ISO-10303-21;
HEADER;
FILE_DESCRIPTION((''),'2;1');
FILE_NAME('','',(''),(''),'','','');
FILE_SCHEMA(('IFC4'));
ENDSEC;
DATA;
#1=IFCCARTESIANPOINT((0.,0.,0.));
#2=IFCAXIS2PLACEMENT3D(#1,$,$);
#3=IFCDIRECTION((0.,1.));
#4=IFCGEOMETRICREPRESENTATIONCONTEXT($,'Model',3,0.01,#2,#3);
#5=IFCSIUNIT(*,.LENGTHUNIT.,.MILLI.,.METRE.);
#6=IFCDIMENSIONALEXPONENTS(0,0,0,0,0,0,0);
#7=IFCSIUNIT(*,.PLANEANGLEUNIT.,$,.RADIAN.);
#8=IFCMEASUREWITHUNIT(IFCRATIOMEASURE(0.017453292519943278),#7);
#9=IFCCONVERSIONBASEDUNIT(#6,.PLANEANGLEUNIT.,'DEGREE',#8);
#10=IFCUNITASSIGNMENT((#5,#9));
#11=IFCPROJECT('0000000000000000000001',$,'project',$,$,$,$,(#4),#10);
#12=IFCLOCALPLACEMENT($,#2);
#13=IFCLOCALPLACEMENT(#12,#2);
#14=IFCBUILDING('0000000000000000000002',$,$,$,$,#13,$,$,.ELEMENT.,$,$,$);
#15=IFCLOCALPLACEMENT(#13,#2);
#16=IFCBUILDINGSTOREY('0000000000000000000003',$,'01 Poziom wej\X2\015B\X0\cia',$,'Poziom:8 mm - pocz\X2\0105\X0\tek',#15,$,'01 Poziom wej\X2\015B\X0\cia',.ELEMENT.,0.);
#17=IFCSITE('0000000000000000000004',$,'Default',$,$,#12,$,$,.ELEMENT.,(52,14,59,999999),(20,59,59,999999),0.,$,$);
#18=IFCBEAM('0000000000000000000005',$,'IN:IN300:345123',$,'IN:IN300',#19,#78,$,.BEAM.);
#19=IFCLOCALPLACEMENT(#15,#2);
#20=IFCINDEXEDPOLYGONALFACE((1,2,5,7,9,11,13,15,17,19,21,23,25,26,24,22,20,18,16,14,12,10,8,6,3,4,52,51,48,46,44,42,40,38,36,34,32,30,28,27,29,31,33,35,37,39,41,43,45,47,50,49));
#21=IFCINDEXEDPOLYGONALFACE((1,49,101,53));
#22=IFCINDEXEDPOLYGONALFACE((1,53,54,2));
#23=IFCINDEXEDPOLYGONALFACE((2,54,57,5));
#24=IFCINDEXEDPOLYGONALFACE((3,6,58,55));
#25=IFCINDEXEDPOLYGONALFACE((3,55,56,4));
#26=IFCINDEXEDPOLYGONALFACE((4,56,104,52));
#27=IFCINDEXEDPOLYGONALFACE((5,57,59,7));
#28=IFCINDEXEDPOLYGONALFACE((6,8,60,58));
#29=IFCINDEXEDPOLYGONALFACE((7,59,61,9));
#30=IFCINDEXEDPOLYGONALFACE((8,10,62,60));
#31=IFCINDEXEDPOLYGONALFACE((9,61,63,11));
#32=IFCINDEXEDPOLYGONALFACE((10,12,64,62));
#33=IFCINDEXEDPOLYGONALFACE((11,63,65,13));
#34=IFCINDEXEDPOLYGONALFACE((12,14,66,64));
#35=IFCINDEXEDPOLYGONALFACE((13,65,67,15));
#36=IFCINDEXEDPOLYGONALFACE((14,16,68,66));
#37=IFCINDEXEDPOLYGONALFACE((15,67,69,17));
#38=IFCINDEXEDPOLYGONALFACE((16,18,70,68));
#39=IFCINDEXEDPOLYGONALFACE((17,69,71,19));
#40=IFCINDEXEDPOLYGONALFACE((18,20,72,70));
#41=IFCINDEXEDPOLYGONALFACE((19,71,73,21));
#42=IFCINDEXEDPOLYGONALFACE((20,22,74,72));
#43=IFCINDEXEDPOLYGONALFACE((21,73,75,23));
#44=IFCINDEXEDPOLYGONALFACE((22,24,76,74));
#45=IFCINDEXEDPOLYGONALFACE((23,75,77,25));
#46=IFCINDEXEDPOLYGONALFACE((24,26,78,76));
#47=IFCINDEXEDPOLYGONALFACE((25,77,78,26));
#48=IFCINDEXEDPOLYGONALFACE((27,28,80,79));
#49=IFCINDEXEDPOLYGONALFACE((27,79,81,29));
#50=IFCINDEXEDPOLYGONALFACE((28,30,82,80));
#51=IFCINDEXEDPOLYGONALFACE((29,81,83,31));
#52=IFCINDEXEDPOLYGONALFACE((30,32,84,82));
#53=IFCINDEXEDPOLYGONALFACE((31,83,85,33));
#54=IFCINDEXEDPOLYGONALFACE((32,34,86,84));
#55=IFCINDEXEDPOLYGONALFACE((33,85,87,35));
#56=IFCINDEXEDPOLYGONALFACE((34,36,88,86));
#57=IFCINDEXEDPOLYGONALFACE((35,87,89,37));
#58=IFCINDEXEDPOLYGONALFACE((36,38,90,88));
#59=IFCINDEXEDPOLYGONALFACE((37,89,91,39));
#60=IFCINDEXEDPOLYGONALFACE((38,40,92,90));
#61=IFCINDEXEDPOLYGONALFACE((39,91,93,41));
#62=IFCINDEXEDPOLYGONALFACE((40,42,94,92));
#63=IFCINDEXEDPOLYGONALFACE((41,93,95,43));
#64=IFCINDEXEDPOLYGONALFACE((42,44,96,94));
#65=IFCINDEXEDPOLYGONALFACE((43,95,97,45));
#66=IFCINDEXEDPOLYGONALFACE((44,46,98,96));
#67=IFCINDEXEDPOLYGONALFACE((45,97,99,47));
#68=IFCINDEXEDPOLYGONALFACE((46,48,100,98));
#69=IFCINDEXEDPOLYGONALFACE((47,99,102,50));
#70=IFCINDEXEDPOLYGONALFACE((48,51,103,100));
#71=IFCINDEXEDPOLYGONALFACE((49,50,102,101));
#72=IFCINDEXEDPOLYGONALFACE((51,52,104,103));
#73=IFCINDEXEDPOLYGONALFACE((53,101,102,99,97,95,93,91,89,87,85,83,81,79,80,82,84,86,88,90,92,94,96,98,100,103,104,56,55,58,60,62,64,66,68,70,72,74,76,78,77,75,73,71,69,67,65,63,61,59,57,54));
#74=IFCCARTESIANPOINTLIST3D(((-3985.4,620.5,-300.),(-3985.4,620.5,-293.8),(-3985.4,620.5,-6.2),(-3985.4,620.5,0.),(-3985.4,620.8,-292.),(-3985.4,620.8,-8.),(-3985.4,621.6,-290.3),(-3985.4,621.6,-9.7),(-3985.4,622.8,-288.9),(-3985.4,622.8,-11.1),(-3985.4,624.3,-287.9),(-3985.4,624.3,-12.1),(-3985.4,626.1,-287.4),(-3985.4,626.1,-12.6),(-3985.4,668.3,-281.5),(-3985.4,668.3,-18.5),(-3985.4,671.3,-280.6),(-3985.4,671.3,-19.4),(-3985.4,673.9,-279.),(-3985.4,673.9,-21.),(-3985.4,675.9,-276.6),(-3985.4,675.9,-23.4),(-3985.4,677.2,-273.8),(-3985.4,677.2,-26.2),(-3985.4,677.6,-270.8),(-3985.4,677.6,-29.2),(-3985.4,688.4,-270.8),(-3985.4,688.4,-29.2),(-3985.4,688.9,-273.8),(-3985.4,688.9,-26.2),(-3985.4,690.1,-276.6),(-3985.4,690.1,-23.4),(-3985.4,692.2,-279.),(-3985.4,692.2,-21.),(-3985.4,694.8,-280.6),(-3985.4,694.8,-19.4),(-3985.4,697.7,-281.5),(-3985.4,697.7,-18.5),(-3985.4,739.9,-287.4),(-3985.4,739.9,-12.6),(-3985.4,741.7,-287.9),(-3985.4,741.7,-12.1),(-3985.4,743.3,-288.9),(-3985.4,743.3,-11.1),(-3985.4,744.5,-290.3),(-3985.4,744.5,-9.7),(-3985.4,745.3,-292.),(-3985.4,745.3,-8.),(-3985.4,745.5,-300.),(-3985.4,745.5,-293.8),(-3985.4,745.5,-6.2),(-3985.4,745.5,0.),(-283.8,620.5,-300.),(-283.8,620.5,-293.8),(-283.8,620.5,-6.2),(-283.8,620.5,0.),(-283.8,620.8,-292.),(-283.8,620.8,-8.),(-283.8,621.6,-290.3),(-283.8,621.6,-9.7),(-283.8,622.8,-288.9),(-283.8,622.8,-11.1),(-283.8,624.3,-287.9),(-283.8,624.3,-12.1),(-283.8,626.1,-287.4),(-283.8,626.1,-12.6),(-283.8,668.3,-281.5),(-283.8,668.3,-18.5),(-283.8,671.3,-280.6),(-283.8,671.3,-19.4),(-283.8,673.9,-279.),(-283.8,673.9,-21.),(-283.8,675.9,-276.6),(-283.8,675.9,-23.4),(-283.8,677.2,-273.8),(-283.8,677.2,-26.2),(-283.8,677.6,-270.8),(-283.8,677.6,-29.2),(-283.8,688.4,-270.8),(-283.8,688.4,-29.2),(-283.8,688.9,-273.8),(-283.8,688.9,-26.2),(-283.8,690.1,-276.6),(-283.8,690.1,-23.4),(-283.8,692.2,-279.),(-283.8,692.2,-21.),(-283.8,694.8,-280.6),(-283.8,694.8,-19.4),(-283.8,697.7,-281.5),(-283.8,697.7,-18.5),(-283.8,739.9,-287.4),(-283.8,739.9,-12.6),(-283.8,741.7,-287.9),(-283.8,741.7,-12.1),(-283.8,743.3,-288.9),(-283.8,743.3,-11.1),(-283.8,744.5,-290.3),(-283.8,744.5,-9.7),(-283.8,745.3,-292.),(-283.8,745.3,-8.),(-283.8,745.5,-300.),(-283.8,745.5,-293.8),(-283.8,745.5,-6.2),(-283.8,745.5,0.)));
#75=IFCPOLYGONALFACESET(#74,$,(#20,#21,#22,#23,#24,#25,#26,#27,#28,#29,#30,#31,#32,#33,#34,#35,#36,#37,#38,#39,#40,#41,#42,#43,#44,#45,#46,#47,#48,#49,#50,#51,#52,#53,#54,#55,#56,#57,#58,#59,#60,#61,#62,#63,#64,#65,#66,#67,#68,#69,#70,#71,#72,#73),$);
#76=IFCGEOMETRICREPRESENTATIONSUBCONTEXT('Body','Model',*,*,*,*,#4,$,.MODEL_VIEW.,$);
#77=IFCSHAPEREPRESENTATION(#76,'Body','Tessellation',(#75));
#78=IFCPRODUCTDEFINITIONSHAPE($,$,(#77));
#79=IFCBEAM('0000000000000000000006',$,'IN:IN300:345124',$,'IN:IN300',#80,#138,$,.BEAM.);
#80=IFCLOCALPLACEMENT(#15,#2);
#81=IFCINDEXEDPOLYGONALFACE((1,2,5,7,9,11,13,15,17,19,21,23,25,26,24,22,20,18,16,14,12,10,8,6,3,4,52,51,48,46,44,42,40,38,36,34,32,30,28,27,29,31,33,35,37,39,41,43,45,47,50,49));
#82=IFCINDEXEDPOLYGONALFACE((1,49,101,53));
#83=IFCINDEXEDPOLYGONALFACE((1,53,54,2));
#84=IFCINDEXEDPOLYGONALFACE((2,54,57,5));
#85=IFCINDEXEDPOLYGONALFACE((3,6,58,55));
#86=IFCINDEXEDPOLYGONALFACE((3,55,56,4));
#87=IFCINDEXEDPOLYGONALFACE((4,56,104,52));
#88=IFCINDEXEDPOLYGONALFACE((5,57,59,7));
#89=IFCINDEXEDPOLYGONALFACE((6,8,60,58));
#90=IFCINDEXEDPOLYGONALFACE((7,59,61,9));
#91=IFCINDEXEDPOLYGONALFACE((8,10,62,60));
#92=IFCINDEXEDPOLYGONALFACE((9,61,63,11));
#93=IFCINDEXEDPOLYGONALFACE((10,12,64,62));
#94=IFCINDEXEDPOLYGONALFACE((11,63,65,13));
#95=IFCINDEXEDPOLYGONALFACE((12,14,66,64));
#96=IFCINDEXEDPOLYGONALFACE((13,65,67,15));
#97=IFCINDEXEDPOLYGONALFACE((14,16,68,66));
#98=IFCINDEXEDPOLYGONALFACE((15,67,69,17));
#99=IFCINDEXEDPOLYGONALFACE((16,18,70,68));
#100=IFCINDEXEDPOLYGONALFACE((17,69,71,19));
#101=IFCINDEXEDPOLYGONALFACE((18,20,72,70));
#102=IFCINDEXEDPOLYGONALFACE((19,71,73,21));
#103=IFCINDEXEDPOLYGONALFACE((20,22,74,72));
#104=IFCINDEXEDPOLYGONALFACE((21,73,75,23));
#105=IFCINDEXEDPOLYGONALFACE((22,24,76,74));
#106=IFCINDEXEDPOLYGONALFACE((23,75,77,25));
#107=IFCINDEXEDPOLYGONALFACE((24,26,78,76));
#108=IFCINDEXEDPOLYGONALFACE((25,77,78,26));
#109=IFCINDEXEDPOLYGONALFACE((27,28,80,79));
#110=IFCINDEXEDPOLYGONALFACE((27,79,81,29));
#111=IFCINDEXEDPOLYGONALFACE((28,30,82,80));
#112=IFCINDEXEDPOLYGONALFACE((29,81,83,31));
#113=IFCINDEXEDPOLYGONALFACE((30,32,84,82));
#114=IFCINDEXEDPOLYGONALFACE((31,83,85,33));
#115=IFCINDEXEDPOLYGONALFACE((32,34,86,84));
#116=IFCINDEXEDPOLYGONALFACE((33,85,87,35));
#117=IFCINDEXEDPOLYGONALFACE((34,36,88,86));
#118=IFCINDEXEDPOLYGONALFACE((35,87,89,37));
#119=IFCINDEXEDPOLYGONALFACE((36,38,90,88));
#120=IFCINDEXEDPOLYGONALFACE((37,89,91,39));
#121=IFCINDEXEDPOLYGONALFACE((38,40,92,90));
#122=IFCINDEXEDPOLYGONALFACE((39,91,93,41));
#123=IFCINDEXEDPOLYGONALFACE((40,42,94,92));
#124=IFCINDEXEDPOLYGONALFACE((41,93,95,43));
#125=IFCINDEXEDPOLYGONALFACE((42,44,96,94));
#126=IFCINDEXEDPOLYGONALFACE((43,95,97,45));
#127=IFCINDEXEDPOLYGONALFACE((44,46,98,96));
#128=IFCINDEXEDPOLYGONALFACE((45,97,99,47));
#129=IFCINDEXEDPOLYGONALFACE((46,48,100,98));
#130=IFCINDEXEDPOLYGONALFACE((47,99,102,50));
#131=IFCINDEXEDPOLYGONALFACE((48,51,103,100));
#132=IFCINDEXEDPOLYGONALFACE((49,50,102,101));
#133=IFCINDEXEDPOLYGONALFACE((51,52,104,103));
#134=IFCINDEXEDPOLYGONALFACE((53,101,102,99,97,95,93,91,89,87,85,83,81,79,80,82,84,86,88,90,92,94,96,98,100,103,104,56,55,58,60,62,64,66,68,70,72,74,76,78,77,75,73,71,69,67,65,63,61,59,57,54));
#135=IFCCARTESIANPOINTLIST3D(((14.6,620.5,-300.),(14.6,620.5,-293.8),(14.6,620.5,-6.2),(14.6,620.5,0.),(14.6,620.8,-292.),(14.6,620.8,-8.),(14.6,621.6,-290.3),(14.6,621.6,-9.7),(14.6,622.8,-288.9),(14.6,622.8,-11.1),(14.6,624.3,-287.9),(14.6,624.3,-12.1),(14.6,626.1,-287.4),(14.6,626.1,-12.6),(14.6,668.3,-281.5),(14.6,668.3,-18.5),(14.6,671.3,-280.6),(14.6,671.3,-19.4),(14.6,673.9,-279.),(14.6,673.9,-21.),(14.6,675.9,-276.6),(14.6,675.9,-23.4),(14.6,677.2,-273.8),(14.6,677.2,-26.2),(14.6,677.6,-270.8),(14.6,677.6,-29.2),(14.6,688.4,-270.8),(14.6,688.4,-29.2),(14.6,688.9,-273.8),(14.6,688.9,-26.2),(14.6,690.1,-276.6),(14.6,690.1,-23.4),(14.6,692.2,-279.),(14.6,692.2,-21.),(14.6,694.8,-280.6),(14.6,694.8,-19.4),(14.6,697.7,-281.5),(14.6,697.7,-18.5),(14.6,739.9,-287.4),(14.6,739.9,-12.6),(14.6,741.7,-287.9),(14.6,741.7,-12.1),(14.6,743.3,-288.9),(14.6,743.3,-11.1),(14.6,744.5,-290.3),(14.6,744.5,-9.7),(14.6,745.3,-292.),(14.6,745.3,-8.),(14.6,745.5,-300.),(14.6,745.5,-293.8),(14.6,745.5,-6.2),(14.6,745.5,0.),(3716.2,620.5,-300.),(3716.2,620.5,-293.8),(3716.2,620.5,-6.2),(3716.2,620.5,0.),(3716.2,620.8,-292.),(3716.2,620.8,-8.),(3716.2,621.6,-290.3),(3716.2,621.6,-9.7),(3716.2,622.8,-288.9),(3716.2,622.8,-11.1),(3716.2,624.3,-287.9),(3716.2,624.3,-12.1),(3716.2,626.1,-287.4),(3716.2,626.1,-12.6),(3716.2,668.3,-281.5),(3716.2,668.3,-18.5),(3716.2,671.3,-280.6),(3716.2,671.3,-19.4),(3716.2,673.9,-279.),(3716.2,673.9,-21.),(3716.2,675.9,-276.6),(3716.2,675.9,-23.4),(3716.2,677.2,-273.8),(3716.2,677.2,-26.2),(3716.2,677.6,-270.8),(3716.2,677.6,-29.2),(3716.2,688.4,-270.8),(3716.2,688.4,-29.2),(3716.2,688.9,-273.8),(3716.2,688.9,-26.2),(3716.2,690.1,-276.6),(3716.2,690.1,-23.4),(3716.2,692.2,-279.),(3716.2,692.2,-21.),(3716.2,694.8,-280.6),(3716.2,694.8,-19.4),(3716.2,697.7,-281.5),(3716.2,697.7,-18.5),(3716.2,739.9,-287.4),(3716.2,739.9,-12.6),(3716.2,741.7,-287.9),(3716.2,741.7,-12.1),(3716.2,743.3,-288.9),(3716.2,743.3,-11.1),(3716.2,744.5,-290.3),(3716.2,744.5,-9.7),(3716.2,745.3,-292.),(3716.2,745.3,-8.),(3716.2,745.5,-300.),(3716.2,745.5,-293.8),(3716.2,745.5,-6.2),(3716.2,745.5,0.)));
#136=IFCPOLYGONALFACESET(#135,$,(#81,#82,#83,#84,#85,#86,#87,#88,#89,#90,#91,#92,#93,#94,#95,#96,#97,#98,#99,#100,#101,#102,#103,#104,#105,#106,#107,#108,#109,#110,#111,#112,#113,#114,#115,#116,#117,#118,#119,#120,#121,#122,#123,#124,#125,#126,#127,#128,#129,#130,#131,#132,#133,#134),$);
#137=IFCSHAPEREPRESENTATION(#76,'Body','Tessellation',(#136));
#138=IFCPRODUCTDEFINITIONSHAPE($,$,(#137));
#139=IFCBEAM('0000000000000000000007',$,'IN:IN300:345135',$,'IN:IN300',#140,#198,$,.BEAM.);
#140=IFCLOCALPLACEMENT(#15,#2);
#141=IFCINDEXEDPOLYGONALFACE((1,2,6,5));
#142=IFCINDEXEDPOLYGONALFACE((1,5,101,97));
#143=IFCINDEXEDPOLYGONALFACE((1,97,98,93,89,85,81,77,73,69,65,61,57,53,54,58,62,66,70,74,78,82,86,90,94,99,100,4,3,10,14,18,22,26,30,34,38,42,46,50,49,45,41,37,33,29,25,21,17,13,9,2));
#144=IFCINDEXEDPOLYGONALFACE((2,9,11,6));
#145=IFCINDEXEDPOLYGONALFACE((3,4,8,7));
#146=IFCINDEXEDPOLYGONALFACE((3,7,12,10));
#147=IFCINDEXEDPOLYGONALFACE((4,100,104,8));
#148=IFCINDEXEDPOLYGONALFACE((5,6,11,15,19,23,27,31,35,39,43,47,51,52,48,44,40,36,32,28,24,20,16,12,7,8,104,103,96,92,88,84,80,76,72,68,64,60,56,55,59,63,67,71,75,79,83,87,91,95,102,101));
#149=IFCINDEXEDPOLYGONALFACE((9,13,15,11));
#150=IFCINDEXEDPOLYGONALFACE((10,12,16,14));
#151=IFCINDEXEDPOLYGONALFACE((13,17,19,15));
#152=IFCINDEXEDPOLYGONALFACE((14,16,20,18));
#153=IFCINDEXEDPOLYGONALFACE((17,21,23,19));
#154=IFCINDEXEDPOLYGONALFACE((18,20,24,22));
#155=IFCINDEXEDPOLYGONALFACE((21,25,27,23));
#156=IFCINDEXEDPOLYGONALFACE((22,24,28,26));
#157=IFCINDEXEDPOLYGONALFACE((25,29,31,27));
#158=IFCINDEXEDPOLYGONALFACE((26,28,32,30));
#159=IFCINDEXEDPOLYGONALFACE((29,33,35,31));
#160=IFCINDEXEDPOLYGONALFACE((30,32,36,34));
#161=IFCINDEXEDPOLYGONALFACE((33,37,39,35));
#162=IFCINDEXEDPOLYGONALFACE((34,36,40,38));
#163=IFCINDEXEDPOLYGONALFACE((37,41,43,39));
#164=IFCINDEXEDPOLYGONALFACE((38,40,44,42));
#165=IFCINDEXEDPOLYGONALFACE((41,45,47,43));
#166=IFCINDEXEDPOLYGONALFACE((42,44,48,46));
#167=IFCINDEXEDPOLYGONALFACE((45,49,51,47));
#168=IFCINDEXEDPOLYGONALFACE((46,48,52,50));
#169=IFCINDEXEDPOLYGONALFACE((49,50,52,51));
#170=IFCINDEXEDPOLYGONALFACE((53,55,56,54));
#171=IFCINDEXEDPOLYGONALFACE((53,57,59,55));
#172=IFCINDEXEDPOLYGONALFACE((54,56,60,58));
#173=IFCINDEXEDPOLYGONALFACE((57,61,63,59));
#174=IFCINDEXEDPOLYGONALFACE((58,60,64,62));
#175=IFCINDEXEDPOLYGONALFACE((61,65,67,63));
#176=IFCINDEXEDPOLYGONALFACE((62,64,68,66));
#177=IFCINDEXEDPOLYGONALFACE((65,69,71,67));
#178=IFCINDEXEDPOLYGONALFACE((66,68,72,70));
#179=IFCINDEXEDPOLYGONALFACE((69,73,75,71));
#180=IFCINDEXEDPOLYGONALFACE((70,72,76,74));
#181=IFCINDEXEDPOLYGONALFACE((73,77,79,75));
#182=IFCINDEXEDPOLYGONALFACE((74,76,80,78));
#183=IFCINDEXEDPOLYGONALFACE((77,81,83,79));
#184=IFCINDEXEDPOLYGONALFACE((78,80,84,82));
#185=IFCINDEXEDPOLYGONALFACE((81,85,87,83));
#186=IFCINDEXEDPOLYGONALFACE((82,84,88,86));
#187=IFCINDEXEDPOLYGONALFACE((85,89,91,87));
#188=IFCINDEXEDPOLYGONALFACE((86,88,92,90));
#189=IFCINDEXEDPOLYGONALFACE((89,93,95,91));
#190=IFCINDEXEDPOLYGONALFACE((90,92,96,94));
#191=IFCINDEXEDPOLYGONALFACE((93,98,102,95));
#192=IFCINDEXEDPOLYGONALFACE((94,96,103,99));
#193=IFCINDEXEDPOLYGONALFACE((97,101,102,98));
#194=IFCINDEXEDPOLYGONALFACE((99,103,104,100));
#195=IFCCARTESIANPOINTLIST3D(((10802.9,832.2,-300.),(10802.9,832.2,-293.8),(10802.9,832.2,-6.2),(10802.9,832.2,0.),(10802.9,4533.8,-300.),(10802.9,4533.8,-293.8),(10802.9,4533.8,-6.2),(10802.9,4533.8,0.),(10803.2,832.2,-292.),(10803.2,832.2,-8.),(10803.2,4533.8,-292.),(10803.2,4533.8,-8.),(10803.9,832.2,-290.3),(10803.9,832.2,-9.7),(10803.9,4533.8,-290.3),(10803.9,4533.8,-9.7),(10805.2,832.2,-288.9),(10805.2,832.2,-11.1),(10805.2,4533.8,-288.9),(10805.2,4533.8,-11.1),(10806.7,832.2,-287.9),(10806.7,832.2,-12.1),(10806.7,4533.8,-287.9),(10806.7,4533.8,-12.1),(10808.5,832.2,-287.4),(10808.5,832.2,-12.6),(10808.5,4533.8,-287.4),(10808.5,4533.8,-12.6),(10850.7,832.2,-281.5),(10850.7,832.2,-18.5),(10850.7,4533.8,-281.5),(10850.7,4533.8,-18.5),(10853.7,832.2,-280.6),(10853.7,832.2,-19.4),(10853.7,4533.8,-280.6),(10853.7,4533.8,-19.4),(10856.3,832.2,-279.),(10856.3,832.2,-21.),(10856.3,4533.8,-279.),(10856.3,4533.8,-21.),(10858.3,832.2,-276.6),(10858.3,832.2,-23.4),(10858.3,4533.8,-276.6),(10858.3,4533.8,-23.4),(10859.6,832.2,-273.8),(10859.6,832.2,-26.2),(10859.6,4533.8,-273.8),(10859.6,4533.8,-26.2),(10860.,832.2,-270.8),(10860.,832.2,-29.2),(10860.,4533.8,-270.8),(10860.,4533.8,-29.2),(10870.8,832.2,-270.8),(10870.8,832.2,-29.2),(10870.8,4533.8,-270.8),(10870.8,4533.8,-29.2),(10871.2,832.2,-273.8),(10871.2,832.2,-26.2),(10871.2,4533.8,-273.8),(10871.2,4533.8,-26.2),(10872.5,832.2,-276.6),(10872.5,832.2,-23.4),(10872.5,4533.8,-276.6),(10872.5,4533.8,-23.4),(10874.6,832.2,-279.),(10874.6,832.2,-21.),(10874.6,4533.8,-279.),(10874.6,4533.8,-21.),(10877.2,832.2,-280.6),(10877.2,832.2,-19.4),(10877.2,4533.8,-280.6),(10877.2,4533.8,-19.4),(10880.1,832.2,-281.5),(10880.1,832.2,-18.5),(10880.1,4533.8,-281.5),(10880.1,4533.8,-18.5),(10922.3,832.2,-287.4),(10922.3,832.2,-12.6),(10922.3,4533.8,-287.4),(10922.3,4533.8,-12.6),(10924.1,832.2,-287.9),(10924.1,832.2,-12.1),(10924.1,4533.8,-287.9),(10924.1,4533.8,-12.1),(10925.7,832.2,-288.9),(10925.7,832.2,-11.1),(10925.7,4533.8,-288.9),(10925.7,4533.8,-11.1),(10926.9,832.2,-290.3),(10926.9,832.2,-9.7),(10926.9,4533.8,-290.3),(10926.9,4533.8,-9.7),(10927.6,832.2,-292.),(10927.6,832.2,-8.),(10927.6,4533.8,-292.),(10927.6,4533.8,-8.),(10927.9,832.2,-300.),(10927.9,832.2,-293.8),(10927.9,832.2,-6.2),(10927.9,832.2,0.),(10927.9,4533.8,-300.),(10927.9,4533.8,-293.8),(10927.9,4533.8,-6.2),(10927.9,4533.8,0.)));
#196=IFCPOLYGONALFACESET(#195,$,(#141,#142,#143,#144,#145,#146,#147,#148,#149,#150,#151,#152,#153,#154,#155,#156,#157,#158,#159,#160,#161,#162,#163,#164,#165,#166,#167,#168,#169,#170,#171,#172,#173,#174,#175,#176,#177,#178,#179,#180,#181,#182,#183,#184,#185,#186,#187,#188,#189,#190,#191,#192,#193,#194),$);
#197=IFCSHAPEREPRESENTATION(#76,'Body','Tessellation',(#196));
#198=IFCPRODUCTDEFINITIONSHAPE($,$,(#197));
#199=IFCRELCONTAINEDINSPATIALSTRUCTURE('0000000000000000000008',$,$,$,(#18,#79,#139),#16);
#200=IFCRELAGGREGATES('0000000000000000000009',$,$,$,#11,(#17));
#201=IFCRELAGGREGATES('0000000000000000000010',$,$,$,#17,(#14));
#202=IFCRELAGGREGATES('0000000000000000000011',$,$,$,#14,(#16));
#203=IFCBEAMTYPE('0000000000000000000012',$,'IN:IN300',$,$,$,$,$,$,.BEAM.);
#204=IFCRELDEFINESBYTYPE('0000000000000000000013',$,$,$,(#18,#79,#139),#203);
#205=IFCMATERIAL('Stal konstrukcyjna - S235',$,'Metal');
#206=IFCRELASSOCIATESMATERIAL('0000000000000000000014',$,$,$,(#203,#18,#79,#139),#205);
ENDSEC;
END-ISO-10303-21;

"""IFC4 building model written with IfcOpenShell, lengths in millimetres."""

from ifc_helpers import new_model, entity, si_unit, converted_unit, direction, frame, origin, place, context, subcontext, project, spatial, line, arc, indexed_curve, outline, extrude, source, transform, mapped, material, type_object, type_shapes, element, save


model = new_model("IFC4")

# Units and contexts
model_context = context("Model", 3, precision=0.01, world=origin(), true_north=direction((0.0, 1.0)))
body_context = subcontext(model_context, "Body", "Model", "MODEL_VIEW")
ifc_project = project(units=[si_unit("LENGTHUNIT", "METRE", prefix="MILLI"), converted_unit("PLANEANGLEUNIT", "DEGREE", entity("IfcRatioMeasure", 0.017453292519943278), si_unit("PLANEANGLEUNIT", "RADIAN"), dimensions=[0, 0, 0, 0, 0, 0, 0])], contexts=[model_context])

# Site, building, storey
site_placement = place(None, origin())
site = spatial("IfcSite", under=ifc_project, at=site_placement, Name="Default", CompositionType="ELEMENT", RefLatitude=(52, 14, 59, 999999), RefLongitude=(20, 59, 59, 999999), RefElevation=0.0)
building_placement = place(site_placement, origin())
building = spatial("IfcBuilding", under=site, at=building_placement, CompositionType="ELEMENT")
storey_placement = place(building_placement, origin())
storey = spatial("IfcBuildingStorey", under=building, at=storey_placement, Name="01 Poziom wejścia", ObjectType="Poziom:8 mm - początek", LongName="01 Poziom wejścia", CompositionType="ELEMENT", Elevation=0.0)

# Beams
ifc_material = material(Name="Stal konstrukcyjna - S235", Category="Metal")
beam_type_1 = type_object("IfcBeamType", Name="IN:IN300", PredefinedType="BEAM", material=ifc_material)
shared_shape_1 = source(origin(), body_context, "Body", "SweptSolid", [
    extrude(outline(indexed_curve([(143.8, -62.5), (150.0, -62.5), (150.0, 62.5), (143.8, 62.5), (139.6, 60.9), (137.4, 56.9), (131.5, 14.7), (127.9, 8.1), (120.8, 5.4), (-120.8, 5.4), (-127.9, 8.1), (-131.5, 14.7), (-137.4, 56.9), (-139.6, 60.9), (-143.8, 62.5), (-150.0, 62.5), (-150.0, -62.5), (-143.8, -62.5), (-139.6, -60.9), (-137.4, -56.9), (-131.5, -14.7), (-127.9, -8.1), (-120.8, -5.4), (120.8, -5.4), (127.9, -8.1), (131.5, -14.7), (137.4, -56.9), (139.6, -60.9)], segments=[line(1, 2, 3, 4), arc(4, 5, 6), line(6, 7), arc(7, 8, 9), line(9, 10), arc(10, 11, 12), line(12, 13), arc(13, 14, 15), line(15, 16, 17, 18), arc(18, 19, 20), line(20, 21), arc(21, 22, 23), line(23, 24), arc(24, 25, 26), line(26, 27), arc(27, 28, 1)], self_intersect=False)), frame((-1850.8, 0.0, 0.0), z_axis=(1.0, 0.0, 0.0), x_axis=(0.0, 0.0, -1.0)), (0.0, 0.0, 1.0), 3701.6),
])
type_shapes(beam_type_1, [shared_shape_1])
for number, where, name in (
    (1, (-2134.6, 683.0, -150.0), "IN:IN300:345123"),
    (2, (1865.4, 683.0, -150.0), "IN:IN300:345124"),
):
    element("IfcBeam", number, at=place(storey_placement, frame(where)), inside=storey, type_object=beam_type_1, material=ifc_material, Name=name, ObjectType="IN:IN300", PredefinedType="BEAM", context=body_context, shape_type="MappedRepresentation", body=[
        mapped(shared_shape_1, transform((0.0, 0.0, 0.0), scale=1.0)),
    ])
for number, where, z_axis, x_axis, name in (
    (3, (10865.4, 2683.0, -150.0), (0.0, 0.0, 1.0), (0.0, -1.0, 0.0), "IN:IN300:345135"),
):
    element("IfcBeam", number, at=place(storey_placement, frame(where, z_axis=z_axis, x_axis=x_axis)), inside=storey, type_object=beam_type_1, material=ifc_material, Name=name, ObjectType="IN:IN300", PredefinedType="BEAM", context=body_context, shape_type="MappedRepresentation", body=[
        mapped(shared_shape_1, transform((0.0, 0.0, 0.0), scale=1.0)),
    ])

save(model, "model.ifc")
